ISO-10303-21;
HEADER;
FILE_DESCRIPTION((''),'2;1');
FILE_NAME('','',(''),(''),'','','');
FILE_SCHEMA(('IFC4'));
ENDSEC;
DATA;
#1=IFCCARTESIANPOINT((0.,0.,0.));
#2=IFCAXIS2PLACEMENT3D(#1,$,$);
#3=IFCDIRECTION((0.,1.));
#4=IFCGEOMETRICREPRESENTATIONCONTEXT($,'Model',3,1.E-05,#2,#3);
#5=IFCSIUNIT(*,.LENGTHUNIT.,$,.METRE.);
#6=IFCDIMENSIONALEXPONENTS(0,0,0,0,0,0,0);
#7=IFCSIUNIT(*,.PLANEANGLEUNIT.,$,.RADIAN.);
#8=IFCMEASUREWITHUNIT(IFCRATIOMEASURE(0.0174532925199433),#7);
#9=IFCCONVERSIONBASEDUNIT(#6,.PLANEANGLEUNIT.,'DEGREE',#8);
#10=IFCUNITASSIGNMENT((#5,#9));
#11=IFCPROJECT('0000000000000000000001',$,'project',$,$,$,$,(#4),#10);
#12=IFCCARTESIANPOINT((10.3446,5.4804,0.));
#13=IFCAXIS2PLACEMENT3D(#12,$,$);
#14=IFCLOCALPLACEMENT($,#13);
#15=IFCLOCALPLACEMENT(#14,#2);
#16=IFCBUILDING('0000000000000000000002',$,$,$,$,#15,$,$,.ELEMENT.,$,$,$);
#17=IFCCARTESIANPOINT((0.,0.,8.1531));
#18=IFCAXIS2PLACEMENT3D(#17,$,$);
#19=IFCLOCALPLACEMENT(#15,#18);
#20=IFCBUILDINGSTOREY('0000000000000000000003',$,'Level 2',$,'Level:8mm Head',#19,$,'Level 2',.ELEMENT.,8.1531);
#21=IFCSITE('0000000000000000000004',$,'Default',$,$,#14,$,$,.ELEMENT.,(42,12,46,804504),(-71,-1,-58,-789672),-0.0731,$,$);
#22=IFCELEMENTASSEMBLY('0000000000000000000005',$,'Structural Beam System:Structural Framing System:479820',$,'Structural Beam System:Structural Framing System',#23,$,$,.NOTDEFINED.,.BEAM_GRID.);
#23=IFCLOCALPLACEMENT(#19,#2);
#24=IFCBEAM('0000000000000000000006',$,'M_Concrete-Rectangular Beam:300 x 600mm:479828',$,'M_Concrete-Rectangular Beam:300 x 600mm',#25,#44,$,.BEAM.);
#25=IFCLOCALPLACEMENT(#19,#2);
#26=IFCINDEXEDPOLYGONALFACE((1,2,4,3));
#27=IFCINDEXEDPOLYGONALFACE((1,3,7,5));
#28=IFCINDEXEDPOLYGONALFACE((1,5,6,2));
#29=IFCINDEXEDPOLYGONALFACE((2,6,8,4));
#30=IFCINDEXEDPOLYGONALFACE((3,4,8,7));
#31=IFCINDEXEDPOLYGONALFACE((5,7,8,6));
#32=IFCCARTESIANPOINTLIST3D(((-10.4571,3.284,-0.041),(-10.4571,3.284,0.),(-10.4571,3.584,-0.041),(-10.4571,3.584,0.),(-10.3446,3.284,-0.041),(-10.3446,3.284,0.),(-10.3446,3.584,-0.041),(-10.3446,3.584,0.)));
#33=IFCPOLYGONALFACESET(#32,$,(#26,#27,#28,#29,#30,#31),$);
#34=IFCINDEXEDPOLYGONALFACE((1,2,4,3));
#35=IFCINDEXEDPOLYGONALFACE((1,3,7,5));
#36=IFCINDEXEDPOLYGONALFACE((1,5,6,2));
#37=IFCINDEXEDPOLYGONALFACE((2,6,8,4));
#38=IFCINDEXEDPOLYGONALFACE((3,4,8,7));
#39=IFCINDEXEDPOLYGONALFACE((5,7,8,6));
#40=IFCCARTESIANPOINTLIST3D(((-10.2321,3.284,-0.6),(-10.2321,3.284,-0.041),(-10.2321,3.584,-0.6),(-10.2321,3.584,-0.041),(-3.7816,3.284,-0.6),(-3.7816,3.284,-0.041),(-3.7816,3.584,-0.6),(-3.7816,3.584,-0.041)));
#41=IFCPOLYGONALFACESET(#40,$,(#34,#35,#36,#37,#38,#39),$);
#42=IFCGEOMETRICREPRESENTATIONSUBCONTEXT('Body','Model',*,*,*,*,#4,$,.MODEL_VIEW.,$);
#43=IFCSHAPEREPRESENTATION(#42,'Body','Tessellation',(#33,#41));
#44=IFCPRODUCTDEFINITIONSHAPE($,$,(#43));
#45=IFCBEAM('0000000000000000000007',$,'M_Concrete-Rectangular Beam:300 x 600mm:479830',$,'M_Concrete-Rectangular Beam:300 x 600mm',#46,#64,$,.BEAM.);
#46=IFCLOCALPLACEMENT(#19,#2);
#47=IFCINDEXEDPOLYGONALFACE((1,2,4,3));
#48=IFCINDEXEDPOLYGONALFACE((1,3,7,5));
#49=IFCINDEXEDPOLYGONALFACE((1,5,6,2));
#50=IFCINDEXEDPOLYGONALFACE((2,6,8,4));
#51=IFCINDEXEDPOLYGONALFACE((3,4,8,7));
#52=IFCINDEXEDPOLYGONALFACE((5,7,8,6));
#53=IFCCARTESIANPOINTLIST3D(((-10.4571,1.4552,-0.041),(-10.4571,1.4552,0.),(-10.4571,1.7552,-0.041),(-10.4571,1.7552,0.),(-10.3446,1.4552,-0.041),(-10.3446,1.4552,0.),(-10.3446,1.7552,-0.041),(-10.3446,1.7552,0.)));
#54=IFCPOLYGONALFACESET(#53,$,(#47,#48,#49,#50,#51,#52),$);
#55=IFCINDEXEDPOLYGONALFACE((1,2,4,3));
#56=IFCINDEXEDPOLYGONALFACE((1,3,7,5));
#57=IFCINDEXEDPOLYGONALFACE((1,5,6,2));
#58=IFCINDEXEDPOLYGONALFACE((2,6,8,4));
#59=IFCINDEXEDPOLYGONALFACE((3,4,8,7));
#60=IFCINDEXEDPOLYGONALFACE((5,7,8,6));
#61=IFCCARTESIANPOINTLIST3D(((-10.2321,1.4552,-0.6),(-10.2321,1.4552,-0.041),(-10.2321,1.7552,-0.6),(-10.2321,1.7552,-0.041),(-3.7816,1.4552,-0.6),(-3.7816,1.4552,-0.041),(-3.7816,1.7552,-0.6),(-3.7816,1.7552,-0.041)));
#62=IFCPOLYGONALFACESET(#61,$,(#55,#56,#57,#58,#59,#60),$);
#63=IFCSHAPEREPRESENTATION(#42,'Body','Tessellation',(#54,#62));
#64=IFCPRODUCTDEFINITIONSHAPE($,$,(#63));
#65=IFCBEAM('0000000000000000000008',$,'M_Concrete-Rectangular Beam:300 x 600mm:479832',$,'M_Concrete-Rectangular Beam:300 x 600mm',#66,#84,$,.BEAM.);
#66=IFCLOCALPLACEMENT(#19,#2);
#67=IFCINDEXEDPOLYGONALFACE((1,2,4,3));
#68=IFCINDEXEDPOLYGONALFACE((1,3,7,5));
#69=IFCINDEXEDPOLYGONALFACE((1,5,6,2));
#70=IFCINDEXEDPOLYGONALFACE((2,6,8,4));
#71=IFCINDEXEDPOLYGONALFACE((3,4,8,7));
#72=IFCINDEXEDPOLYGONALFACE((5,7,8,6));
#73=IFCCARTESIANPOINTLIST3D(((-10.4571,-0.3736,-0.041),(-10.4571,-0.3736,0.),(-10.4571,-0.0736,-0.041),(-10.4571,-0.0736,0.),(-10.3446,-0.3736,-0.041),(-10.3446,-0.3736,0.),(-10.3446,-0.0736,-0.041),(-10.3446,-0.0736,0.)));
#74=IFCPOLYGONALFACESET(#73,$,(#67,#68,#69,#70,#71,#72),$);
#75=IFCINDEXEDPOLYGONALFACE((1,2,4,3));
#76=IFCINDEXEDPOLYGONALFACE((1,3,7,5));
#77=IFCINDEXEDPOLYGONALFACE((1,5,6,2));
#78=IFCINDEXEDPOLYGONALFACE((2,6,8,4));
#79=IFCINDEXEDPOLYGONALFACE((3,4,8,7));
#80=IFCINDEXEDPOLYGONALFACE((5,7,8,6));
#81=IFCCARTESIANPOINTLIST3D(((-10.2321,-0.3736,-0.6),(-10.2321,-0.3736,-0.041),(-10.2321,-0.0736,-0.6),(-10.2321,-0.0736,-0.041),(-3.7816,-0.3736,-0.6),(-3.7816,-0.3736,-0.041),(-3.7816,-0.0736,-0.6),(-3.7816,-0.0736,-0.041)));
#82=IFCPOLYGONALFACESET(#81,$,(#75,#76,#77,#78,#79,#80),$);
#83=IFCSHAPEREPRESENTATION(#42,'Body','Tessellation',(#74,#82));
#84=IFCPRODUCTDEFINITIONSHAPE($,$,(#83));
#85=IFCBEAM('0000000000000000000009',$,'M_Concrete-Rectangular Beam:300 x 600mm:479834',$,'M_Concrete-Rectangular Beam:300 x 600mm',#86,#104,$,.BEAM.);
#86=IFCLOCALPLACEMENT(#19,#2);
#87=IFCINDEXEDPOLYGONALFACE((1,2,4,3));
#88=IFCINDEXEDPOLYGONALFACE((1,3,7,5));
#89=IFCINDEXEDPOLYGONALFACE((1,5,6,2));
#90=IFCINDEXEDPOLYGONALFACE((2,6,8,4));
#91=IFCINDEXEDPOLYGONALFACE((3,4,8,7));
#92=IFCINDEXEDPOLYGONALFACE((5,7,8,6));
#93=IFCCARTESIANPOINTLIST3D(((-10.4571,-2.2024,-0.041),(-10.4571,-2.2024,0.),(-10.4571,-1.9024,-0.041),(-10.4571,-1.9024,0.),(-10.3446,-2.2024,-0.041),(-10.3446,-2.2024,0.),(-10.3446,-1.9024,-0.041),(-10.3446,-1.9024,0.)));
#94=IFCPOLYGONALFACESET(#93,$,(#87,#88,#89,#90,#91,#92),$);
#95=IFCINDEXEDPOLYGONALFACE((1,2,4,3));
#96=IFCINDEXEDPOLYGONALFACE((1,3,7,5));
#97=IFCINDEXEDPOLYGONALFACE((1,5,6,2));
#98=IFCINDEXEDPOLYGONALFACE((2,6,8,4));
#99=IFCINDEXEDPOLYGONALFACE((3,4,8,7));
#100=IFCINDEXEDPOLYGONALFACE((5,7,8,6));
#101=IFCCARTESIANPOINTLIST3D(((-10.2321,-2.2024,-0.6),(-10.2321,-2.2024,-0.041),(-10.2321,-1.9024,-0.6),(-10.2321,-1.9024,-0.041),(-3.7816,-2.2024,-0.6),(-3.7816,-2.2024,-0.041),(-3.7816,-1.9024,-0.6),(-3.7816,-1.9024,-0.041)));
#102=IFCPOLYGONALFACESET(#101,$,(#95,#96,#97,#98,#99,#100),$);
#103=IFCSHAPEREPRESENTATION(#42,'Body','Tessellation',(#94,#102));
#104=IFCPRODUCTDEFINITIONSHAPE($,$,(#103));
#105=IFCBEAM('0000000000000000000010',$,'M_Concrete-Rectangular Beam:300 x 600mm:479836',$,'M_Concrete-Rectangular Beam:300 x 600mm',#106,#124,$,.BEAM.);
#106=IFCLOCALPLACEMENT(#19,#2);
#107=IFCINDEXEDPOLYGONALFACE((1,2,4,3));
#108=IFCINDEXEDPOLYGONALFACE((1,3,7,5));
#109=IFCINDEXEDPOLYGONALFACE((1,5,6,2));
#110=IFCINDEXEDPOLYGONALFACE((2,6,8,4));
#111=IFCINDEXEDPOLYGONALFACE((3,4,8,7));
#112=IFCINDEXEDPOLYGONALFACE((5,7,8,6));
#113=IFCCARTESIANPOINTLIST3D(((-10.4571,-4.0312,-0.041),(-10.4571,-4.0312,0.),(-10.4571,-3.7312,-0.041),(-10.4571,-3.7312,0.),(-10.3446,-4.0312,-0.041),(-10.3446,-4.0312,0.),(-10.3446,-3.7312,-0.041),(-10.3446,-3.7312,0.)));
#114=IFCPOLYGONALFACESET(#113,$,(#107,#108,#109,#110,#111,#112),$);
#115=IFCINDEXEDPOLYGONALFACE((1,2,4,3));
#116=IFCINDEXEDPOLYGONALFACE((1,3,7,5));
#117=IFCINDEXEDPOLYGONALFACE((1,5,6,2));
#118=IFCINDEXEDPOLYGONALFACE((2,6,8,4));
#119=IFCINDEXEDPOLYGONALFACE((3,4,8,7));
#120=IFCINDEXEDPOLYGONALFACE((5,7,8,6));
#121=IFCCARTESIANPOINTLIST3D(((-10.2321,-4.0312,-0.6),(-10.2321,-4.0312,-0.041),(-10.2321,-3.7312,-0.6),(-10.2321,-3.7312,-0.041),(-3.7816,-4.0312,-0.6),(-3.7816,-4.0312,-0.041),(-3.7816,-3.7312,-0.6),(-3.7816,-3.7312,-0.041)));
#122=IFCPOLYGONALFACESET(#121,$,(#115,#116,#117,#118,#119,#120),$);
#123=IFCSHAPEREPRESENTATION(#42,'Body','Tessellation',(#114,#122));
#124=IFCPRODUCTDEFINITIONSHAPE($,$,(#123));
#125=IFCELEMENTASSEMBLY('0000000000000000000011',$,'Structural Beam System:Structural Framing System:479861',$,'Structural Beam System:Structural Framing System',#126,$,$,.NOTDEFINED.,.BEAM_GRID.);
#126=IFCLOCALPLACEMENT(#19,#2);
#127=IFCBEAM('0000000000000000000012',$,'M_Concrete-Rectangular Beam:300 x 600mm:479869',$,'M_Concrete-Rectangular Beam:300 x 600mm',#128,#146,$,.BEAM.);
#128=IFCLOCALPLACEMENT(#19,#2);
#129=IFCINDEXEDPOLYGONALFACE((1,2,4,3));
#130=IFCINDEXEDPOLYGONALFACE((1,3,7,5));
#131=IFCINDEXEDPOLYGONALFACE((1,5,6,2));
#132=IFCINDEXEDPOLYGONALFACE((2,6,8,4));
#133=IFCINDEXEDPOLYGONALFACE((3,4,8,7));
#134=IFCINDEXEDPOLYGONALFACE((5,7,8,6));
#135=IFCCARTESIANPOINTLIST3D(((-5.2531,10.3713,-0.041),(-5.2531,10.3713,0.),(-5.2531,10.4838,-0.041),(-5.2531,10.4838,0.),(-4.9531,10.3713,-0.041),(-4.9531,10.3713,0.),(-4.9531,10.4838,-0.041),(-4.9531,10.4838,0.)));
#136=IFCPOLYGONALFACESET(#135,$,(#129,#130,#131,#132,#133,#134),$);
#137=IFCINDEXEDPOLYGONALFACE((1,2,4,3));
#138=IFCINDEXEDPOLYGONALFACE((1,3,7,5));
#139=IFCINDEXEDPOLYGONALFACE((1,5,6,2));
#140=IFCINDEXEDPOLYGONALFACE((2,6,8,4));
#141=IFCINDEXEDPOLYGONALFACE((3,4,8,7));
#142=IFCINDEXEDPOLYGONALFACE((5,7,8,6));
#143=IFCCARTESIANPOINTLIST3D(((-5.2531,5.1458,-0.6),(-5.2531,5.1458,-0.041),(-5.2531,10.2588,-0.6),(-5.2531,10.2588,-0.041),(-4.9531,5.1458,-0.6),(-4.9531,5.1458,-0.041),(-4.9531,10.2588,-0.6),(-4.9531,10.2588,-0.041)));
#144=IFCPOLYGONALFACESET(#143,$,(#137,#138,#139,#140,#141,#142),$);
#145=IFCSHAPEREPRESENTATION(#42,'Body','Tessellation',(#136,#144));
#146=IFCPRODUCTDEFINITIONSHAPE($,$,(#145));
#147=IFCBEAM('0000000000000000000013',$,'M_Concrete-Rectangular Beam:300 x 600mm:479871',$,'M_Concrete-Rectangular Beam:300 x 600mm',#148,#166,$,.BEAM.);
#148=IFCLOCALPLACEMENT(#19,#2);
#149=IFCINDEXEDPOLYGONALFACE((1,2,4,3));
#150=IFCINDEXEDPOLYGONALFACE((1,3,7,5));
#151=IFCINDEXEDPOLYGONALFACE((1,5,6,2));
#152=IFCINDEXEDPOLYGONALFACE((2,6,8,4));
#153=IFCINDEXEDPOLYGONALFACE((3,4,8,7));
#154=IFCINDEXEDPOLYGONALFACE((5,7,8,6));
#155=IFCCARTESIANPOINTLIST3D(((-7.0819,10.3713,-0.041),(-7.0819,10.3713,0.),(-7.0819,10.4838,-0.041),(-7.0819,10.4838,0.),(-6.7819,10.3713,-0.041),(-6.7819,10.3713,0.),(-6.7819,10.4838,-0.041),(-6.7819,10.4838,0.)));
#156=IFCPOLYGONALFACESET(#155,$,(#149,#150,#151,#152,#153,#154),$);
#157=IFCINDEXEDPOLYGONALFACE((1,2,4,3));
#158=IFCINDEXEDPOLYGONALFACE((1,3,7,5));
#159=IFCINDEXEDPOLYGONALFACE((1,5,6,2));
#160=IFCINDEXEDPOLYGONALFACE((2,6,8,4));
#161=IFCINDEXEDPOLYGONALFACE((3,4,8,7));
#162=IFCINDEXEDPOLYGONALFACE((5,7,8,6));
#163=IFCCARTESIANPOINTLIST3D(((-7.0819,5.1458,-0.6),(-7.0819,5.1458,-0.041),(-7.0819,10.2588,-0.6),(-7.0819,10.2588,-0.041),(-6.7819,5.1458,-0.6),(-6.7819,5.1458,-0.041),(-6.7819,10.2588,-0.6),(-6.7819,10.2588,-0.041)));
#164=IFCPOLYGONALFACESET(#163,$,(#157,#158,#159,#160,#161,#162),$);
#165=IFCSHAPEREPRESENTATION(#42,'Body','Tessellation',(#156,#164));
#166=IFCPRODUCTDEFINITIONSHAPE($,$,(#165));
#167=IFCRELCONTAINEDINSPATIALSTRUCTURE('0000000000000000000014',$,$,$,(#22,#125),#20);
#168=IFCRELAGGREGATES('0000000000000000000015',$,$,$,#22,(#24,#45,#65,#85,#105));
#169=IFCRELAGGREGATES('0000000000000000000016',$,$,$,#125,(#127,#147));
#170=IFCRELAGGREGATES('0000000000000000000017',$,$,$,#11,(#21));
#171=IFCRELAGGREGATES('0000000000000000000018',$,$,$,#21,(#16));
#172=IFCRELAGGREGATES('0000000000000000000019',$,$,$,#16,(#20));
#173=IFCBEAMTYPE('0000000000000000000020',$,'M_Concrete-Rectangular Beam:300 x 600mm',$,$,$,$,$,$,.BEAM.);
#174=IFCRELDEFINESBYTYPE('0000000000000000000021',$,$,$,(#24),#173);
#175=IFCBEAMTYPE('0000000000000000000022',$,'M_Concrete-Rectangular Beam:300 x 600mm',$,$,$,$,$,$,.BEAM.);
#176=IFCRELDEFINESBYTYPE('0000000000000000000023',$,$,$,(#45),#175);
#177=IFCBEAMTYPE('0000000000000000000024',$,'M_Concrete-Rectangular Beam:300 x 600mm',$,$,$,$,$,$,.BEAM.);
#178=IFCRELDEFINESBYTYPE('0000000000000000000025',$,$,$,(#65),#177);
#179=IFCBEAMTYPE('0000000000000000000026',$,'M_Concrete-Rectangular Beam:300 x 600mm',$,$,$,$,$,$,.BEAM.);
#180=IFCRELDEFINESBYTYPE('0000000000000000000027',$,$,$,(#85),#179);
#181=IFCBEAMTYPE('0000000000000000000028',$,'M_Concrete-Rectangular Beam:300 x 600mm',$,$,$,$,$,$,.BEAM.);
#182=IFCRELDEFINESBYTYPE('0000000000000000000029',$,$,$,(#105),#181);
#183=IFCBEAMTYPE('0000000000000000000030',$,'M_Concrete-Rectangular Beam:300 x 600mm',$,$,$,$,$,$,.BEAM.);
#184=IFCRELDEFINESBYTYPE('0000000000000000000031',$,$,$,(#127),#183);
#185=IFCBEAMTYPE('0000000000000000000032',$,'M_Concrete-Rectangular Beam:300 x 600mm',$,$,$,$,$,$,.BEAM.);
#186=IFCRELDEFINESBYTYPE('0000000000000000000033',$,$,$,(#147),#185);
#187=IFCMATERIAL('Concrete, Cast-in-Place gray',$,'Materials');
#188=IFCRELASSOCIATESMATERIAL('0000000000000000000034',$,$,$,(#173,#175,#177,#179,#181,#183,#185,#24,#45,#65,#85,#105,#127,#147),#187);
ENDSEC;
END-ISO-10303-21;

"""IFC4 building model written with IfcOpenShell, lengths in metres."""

from ifc_helpers import new_model, entity, si_unit, converted_unit, direction, frame, frame_2d, origin, place, context, subcontext, project, spatial, rectangle, extrude, source, transform, mapped, material, material_profile, profile_set, profile_usage, type_object, type_shapes, element, aggregate, save


model = new_model("IFC4")

# Units and contexts
model_context = context("Model", 3, precision=1e-05, world=origin(), true_north=direction((0.0, 1.0)))
body_context = subcontext(model_context, "Body", "Model", "MODEL_VIEW")
ifc_project = project(units=[si_unit("LENGTHUNIT", "METRE"), converted_unit("PLANEANGLEUNIT", "DEGREE", entity("IfcRatioMeasure", 0.0174532925199433), si_unit("PLANEANGLEUNIT", "RADIAN"), dimensions=[0, 0, 0, 0, 0, 0, 0])], contexts=[model_context])

# Site, building, storey
site_placement = place(None, frame((10.3446, 5.4804, 0.0)))
site = spatial("IfcSite", under=ifc_project, at=site_placement, Name="Default", CompositionType="ELEMENT", RefLatitude=(42, 12, 46, 804504), RefLongitude=(-71, -1, -58, -789672), RefElevation=-0.0731)
building_placement = place(site_placement, origin())
building = spatial("IfcBuilding", under=site, at=building_placement, CompositionType="ELEMENT")
storey_placement = place(building_placement, frame((0.0, 0.0, 8.1531)))
storey = spatial("IfcBuildingStorey", under=building, at=storey_placement, Name="Level 2", ObjectType="Level:8mm Head", LongName="Level 2", CompositionType="ELEMENT", Elevation=8.1531)

# Element assemblies, beams
assembly_1_placement = place(storey_placement, origin())
assembly_1 = element("IfcElementAssembly", 1, at=assembly_1_placement, inside=storey, Name="Structural Beam System:Structural Framing System:479820", ObjectType="Structural Beam System:Structural Framing System", AssemblyPlace="NOTDEFINED", PredefinedType="BEAM_GRID")
ifc_material_1 = material(Name="Concrete, Cast-in-Place gray", Category="Materials")
ifc_material_profile = material_profile(ifc_material_1, rectangle(XDim=0.559, YDim=0.3, at=frame_2d((0.0, 0.0), x_axis=(1.0, 0.0))), Name="300 x 600mm")
ifc_profile_set = profile_set([ifc_material_profile], Name="300 x 600mm")
ifc_profile_usage_1 = profile_usage(ifc_profile_set, cardinal=8)
beam_type_1 = type_object("IfcBeamType", Name="M_Concrete-Rectangular Beam:300 x 600mm", PredefinedType="BEAM", material=ifc_profile_set)
shared_shape_1 = source(origin(), body_context, "Body", "SweptSolid", [
    extrude(rectangle(XDim=0.041, YDim=0.3, at=frame_2d((0.0, 0.0), x_axis=(1.0, 0.0))), frame((-10.4571, 3.434, 8.1326), z_axis=(1.0, 0.0, 0.0), x_axis=(0.0, 0.0, -1.0)), (0.0, 0.0, 1.0), 0.1125),
    extrude(rectangle(XDim=0.559, YDim=0.3, at=frame_2d((0.0, 0.0), x_axis=(1.0, 0.0))), frame((-10.2321, 3.434, 7.8326), z_axis=(1.0, 0.0, 0.0), x_axis=(0.0, 0.0, -1.0)), (0.0, 0.0, 1.0), 6.4506),
])
type_shapes(beam_type_1, [shared_shape_1])
beam_1_placement = place(assembly_1_placement, frame((0.0, 0.0, -8.1531)))
beam_1 = element("IfcBeam", 2, at=beam_1_placement, type_object=beam_type_1, material=ifc_profile_usage_1, Name="M_Concrete-Rectangular Beam:300 x 600mm:479828", ObjectType="M_Concrete-Rectangular Beam:300 x 600mm", PredefinedType="BEAM", context=body_context, shape_type="MappedRepresentation", body=[
    mapped(shared_shape_1, transform((0.0, 0.0, 0.0), scale=1.0)),
])
ifc_profile_usage_2 = profile_usage(ifc_profile_set, cardinal=8)
beam_type_2 = type_object("IfcBeamType", Name="M_Concrete-Rectangular Beam:300 x 600mm", PredefinedType="BEAM", material=ifc_profile_set)
shared_shape_2 = source(origin(), body_context, "Body", "SweptSolid", [
    extrude(rectangle(XDim=0.041, YDim=0.3, at=frame_2d((0.0, 0.0), x_axis=(1.0, 0.0))), frame((-10.4571, 1.6052, 8.1326), z_axis=(1.0, 0.0, 0.0), x_axis=(0.0, 0.0, -1.0)), (0.0, 0.0, 1.0), 0.1125),
    extrude(rectangle(XDim=0.559, YDim=0.3, at=frame_2d((0.0, 0.0), x_axis=(1.0, 0.0))), frame((-10.2321, 1.6052, 7.8326), z_axis=(1.0, 0.0, 0.0), x_axis=(0.0, 0.0, -1.0)), (0.0, 0.0, 1.0), 6.4506),
])
type_shapes(beam_type_2, [shared_shape_2])
beam_2_placement = place(assembly_1_placement, frame((0.0, 0.0, -8.1531)))
beam_2 = element("IfcBeam", 3, at=beam_2_placement, type_object=beam_type_2, material=ifc_profile_usage_2, Name="M_Concrete-Rectangular Beam:300 x 600mm:479830", ObjectType="M_Concrete-Rectangular Beam:300 x 600mm", PredefinedType="BEAM", context=body_context, shape_type="MappedRepresentation", body=[
    mapped(shared_shape_2, transform((0.0, 0.0, 0.0), scale=1.0)),
])
ifc_profile_usage_3 = profile_usage(ifc_profile_set, cardinal=8)
beam_type_3 = type_object("IfcBeamType", Name="M_Concrete-Rectangular Beam:300 x 600mm", PredefinedType="BEAM", material=ifc_profile_set)
shared_shape_3 = source(origin(), body_context, "Body", "SweptSolid", [
    extrude(rectangle(XDim=0.041, YDim=0.3, at=frame_2d((0.0, 0.0), x_axis=(1.0, 0.0))), frame((-10.4571, -0.2236, 8.1326), z_axis=(1.0, 0.0, 0.0), x_axis=(0.0, 0.0, -1.0)), (0.0, 0.0, 1.0), 0.1125),
    extrude(rectangle(XDim=0.559, YDim=0.3, at=frame_2d((0.0, 0.0), x_axis=(1.0, 0.0))), frame((-10.2321, -0.2236, 7.8326), z_axis=(1.0, 0.0, 0.0), x_axis=(0.0, 0.0, -1.0)), (0.0, 0.0, 1.0), 6.4506),
])
type_shapes(beam_type_3, [shared_shape_3])
beam_3_placement = place(assembly_1_placement, frame((0.0, 0.0, -8.1531)))
beam_3 = element("IfcBeam", 4, at=beam_3_placement, type_object=beam_type_3, material=ifc_profile_usage_3, Name="M_Concrete-Rectangular Beam:300 x 600mm:479832", ObjectType="M_Concrete-Rectangular Beam:300 x 600mm", PredefinedType="BEAM", context=body_context, shape_type="MappedRepresentation", body=[
    mapped(shared_shape_3, transform((0.0, 0.0, 0.0), scale=1.0)),
])
ifc_profile_usage_4 = profile_usage(ifc_profile_set, cardinal=8)
beam_type_4 = type_object("IfcBeamType", Name="M_Concrete-Rectangular Beam:300 x 600mm", PredefinedType="BEAM", material=ifc_profile_set)
shared_shape_4 = source(origin(), body_context, "Body", "SweptSolid", [
    extrude(rectangle(XDim=0.041, YDim=0.3, at=frame_2d((0.0, 0.0), x_axis=(1.0, 0.0))), frame((-10.4571, -2.0524, 8.1326), z_axis=(1.0, 0.0, 0.0), x_axis=(0.0, 0.0, -1.0)), (0.0, 0.0, 1.0), 0.1125),
    extrude(rectangle(XDim=0.559, YDim=0.3, at=frame_2d((0.0, 0.0), x_axis=(1.0, 0.0))), frame((-10.2321, -2.0524, 7.8326), z_axis=(1.0, 0.0, 0.0), x_axis=(0.0, 0.0, -1.0)), (0.0, 0.0, 1.0), 6.4506),
])
type_shapes(beam_type_4, [shared_shape_4])
beam_4_placement = place(assembly_1_placement, frame((0.0, 0.0, -8.1531)))
beam_4 = element("IfcBeam", 5, at=beam_4_placement, type_object=beam_type_4, material=ifc_profile_usage_4, Name="M_Concrete-Rectangular Beam:300 x 600mm:479834", ObjectType="M_Concrete-Rectangular Beam:300 x 600mm", PredefinedType="BEAM", context=body_context, shape_type="MappedRepresentation", body=[
    mapped(shared_shape_4, transform((0.0, 0.0, 0.0), scale=1.0)),
])
ifc_profile_usage_5 = profile_usage(ifc_profile_set, cardinal=8)
beam_type_5 = type_object("IfcBeamType", Name="M_Concrete-Rectangular Beam:300 x 600mm", PredefinedType="BEAM", material=ifc_profile_set)
shared_shape_5 = source(origin(), body_context, "Body", "SweptSolid", [
    extrude(rectangle(XDim=0.041, YDim=0.3, at=frame_2d((0.0, 0.0), x_axis=(1.0, 0.0))), frame((-10.4571, -3.8812, 8.1326), z_axis=(1.0, 0.0, 0.0), x_axis=(0.0, 0.0, -1.0)), (0.0, 0.0, 1.0), 0.1125),
    extrude(rectangle(XDim=0.559, YDim=0.3, at=frame_2d((0.0, 0.0), x_axis=(1.0, 0.0))), frame((-10.2321, -3.8812, 7.8326), z_axis=(1.0, 0.0, 0.0), x_axis=(0.0, 0.0, -1.0)), (0.0, 0.0, 1.0), 6.4506),
])
type_shapes(beam_type_5, [shared_shape_5])
beam_5_placement = place(assembly_1_placement, frame((0.0, 0.0, -8.1531)))
beam_5 = element("IfcBeam", 6, at=beam_5_placement, type_object=beam_type_5, material=ifc_profile_usage_5, Name="M_Concrete-Rectangular Beam:300 x 600mm:479836", ObjectType="M_Concrete-Rectangular Beam:300 x 600mm", PredefinedType="BEAM", context=body_context, shape_type="MappedRepresentation", body=[
    mapped(shared_shape_5, transform((0.0, 0.0, 0.0), scale=1.0)),
])
aggregate(assembly_1, [beam_1, beam_2, beam_3, beam_4, beam_5])
assembly_2_placement = place(storey_placement, origin())
assembly_2 = element("IfcElementAssembly", 7, at=assembly_2_placement, inside=storey, Name="Structural Beam System:Structural Framing System:479861", ObjectType="Structural Beam System:Structural Framing System", AssemblyPlace="NOTDEFINED", PredefinedType="BEAM_GRID")
ifc_profile_usage_6 = profile_usage(ifc_profile_set, cardinal=8)
beam_type_6 = type_object("IfcBeamType", Name="M_Concrete-Rectangular Beam:300 x 600mm", PredefinedType="BEAM", material=ifc_profile_set)
shared_shape_6 = source(origin(), body_context, "Body", "SweptSolid", [
    extrude(rectangle(XDim=0.041, YDim=0.3, at=frame_2d((0.0, 0.0), x_axis=(0.0, 1.0))), frame((-5.1031, 10.4838, 8.1326), z_axis=(0.0, -1.0, 0.0), x_axis=(-1.0, 0.0, 0.0)), (0.0, 0.0, 1.0), 0.1125),
    extrude(rectangle(XDim=0.559, YDim=0.3, at=frame_2d((0.0, 0.0), x_axis=(0.0, 1.0))), frame((-5.1031, 10.2588, 7.8326), z_axis=(0.0, -1.0, 0.0), x_axis=(-1.0, 0.0, 0.0)), (0.0, 0.0, 1.0), 5.113),
])
type_shapes(beam_type_6, [shared_shape_6])
beam_6_placement = place(assembly_2_placement, frame((0.0, 0.0, -8.1531)))
beam_6 = element("IfcBeam", 8, at=beam_6_placement, type_object=beam_type_6, material=ifc_profile_usage_6, Name="M_Concrete-Rectangular Beam:300 x 600mm:479869", ObjectType="M_Concrete-Rectangular Beam:300 x 600mm", PredefinedType="BEAM", context=body_context, shape_type="MappedRepresentation", body=[
    mapped(shared_shape_6, transform((0.0, 0.0, 0.0), scale=1.0)),
])
ifc_profile_usage_7 = profile_usage(ifc_profile_set, cardinal=8)
beam_type_7 = type_object("IfcBeamType", Name="M_Concrete-Rectangular Beam:300 x 600mm", PredefinedType="BEAM", material=ifc_profile_set)
shared_shape_7 = source(origin(), body_context, "Body", "SweptSolid", [
    extrude(rectangle(XDim=0.041, YDim=0.3, at=frame_2d((0.0, 0.0), x_axis=(0.0, 1.0))), frame((-6.9319, 10.4838, 8.1326), z_axis=(0.0, -1.0, 0.0), x_axis=(-1.0, 0.0, 0.0)), (0.0, 0.0, 1.0), 0.1125),
    extrude(rectangle(XDim=0.559, YDim=0.3, at=frame_2d((0.0, 0.0), x_axis=(0.0, 1.0))), frame((-6.9319, 10.2588, 7.8326), z_axis=(0.0, -1.0, 0.0), x_axis=(-1.0, 0.0, 0.0)), (0.0, 0.0, 1.0), 5.113),
])
type_shapes(beam_type_7, [shared_shape_7])
beam_7_placement = place(assembly_2_placement, frame((0.0, 0.0, -8.1531)))
beam_7 = element("IfcBeam", 9, at=beam_7_placement, type_object=beam_type_7, material=ifc_profile_usage_7, Name="M_Concrete-Rectangular Beam:300 x 600mm:479871", ObjectType="M_Concrete-Rectangular Beam:300 x 600mm", PredefinedType="BEAM", context=body_context, shape_type="MappedRepresentation", body=[
    mapped(shared_shape_7, transform((0.0, 0.0, 0.0), scale=1.0)),
])
aggregate(assembly_2, [beam_6, beam_7])

save(model, "model.ifc")
